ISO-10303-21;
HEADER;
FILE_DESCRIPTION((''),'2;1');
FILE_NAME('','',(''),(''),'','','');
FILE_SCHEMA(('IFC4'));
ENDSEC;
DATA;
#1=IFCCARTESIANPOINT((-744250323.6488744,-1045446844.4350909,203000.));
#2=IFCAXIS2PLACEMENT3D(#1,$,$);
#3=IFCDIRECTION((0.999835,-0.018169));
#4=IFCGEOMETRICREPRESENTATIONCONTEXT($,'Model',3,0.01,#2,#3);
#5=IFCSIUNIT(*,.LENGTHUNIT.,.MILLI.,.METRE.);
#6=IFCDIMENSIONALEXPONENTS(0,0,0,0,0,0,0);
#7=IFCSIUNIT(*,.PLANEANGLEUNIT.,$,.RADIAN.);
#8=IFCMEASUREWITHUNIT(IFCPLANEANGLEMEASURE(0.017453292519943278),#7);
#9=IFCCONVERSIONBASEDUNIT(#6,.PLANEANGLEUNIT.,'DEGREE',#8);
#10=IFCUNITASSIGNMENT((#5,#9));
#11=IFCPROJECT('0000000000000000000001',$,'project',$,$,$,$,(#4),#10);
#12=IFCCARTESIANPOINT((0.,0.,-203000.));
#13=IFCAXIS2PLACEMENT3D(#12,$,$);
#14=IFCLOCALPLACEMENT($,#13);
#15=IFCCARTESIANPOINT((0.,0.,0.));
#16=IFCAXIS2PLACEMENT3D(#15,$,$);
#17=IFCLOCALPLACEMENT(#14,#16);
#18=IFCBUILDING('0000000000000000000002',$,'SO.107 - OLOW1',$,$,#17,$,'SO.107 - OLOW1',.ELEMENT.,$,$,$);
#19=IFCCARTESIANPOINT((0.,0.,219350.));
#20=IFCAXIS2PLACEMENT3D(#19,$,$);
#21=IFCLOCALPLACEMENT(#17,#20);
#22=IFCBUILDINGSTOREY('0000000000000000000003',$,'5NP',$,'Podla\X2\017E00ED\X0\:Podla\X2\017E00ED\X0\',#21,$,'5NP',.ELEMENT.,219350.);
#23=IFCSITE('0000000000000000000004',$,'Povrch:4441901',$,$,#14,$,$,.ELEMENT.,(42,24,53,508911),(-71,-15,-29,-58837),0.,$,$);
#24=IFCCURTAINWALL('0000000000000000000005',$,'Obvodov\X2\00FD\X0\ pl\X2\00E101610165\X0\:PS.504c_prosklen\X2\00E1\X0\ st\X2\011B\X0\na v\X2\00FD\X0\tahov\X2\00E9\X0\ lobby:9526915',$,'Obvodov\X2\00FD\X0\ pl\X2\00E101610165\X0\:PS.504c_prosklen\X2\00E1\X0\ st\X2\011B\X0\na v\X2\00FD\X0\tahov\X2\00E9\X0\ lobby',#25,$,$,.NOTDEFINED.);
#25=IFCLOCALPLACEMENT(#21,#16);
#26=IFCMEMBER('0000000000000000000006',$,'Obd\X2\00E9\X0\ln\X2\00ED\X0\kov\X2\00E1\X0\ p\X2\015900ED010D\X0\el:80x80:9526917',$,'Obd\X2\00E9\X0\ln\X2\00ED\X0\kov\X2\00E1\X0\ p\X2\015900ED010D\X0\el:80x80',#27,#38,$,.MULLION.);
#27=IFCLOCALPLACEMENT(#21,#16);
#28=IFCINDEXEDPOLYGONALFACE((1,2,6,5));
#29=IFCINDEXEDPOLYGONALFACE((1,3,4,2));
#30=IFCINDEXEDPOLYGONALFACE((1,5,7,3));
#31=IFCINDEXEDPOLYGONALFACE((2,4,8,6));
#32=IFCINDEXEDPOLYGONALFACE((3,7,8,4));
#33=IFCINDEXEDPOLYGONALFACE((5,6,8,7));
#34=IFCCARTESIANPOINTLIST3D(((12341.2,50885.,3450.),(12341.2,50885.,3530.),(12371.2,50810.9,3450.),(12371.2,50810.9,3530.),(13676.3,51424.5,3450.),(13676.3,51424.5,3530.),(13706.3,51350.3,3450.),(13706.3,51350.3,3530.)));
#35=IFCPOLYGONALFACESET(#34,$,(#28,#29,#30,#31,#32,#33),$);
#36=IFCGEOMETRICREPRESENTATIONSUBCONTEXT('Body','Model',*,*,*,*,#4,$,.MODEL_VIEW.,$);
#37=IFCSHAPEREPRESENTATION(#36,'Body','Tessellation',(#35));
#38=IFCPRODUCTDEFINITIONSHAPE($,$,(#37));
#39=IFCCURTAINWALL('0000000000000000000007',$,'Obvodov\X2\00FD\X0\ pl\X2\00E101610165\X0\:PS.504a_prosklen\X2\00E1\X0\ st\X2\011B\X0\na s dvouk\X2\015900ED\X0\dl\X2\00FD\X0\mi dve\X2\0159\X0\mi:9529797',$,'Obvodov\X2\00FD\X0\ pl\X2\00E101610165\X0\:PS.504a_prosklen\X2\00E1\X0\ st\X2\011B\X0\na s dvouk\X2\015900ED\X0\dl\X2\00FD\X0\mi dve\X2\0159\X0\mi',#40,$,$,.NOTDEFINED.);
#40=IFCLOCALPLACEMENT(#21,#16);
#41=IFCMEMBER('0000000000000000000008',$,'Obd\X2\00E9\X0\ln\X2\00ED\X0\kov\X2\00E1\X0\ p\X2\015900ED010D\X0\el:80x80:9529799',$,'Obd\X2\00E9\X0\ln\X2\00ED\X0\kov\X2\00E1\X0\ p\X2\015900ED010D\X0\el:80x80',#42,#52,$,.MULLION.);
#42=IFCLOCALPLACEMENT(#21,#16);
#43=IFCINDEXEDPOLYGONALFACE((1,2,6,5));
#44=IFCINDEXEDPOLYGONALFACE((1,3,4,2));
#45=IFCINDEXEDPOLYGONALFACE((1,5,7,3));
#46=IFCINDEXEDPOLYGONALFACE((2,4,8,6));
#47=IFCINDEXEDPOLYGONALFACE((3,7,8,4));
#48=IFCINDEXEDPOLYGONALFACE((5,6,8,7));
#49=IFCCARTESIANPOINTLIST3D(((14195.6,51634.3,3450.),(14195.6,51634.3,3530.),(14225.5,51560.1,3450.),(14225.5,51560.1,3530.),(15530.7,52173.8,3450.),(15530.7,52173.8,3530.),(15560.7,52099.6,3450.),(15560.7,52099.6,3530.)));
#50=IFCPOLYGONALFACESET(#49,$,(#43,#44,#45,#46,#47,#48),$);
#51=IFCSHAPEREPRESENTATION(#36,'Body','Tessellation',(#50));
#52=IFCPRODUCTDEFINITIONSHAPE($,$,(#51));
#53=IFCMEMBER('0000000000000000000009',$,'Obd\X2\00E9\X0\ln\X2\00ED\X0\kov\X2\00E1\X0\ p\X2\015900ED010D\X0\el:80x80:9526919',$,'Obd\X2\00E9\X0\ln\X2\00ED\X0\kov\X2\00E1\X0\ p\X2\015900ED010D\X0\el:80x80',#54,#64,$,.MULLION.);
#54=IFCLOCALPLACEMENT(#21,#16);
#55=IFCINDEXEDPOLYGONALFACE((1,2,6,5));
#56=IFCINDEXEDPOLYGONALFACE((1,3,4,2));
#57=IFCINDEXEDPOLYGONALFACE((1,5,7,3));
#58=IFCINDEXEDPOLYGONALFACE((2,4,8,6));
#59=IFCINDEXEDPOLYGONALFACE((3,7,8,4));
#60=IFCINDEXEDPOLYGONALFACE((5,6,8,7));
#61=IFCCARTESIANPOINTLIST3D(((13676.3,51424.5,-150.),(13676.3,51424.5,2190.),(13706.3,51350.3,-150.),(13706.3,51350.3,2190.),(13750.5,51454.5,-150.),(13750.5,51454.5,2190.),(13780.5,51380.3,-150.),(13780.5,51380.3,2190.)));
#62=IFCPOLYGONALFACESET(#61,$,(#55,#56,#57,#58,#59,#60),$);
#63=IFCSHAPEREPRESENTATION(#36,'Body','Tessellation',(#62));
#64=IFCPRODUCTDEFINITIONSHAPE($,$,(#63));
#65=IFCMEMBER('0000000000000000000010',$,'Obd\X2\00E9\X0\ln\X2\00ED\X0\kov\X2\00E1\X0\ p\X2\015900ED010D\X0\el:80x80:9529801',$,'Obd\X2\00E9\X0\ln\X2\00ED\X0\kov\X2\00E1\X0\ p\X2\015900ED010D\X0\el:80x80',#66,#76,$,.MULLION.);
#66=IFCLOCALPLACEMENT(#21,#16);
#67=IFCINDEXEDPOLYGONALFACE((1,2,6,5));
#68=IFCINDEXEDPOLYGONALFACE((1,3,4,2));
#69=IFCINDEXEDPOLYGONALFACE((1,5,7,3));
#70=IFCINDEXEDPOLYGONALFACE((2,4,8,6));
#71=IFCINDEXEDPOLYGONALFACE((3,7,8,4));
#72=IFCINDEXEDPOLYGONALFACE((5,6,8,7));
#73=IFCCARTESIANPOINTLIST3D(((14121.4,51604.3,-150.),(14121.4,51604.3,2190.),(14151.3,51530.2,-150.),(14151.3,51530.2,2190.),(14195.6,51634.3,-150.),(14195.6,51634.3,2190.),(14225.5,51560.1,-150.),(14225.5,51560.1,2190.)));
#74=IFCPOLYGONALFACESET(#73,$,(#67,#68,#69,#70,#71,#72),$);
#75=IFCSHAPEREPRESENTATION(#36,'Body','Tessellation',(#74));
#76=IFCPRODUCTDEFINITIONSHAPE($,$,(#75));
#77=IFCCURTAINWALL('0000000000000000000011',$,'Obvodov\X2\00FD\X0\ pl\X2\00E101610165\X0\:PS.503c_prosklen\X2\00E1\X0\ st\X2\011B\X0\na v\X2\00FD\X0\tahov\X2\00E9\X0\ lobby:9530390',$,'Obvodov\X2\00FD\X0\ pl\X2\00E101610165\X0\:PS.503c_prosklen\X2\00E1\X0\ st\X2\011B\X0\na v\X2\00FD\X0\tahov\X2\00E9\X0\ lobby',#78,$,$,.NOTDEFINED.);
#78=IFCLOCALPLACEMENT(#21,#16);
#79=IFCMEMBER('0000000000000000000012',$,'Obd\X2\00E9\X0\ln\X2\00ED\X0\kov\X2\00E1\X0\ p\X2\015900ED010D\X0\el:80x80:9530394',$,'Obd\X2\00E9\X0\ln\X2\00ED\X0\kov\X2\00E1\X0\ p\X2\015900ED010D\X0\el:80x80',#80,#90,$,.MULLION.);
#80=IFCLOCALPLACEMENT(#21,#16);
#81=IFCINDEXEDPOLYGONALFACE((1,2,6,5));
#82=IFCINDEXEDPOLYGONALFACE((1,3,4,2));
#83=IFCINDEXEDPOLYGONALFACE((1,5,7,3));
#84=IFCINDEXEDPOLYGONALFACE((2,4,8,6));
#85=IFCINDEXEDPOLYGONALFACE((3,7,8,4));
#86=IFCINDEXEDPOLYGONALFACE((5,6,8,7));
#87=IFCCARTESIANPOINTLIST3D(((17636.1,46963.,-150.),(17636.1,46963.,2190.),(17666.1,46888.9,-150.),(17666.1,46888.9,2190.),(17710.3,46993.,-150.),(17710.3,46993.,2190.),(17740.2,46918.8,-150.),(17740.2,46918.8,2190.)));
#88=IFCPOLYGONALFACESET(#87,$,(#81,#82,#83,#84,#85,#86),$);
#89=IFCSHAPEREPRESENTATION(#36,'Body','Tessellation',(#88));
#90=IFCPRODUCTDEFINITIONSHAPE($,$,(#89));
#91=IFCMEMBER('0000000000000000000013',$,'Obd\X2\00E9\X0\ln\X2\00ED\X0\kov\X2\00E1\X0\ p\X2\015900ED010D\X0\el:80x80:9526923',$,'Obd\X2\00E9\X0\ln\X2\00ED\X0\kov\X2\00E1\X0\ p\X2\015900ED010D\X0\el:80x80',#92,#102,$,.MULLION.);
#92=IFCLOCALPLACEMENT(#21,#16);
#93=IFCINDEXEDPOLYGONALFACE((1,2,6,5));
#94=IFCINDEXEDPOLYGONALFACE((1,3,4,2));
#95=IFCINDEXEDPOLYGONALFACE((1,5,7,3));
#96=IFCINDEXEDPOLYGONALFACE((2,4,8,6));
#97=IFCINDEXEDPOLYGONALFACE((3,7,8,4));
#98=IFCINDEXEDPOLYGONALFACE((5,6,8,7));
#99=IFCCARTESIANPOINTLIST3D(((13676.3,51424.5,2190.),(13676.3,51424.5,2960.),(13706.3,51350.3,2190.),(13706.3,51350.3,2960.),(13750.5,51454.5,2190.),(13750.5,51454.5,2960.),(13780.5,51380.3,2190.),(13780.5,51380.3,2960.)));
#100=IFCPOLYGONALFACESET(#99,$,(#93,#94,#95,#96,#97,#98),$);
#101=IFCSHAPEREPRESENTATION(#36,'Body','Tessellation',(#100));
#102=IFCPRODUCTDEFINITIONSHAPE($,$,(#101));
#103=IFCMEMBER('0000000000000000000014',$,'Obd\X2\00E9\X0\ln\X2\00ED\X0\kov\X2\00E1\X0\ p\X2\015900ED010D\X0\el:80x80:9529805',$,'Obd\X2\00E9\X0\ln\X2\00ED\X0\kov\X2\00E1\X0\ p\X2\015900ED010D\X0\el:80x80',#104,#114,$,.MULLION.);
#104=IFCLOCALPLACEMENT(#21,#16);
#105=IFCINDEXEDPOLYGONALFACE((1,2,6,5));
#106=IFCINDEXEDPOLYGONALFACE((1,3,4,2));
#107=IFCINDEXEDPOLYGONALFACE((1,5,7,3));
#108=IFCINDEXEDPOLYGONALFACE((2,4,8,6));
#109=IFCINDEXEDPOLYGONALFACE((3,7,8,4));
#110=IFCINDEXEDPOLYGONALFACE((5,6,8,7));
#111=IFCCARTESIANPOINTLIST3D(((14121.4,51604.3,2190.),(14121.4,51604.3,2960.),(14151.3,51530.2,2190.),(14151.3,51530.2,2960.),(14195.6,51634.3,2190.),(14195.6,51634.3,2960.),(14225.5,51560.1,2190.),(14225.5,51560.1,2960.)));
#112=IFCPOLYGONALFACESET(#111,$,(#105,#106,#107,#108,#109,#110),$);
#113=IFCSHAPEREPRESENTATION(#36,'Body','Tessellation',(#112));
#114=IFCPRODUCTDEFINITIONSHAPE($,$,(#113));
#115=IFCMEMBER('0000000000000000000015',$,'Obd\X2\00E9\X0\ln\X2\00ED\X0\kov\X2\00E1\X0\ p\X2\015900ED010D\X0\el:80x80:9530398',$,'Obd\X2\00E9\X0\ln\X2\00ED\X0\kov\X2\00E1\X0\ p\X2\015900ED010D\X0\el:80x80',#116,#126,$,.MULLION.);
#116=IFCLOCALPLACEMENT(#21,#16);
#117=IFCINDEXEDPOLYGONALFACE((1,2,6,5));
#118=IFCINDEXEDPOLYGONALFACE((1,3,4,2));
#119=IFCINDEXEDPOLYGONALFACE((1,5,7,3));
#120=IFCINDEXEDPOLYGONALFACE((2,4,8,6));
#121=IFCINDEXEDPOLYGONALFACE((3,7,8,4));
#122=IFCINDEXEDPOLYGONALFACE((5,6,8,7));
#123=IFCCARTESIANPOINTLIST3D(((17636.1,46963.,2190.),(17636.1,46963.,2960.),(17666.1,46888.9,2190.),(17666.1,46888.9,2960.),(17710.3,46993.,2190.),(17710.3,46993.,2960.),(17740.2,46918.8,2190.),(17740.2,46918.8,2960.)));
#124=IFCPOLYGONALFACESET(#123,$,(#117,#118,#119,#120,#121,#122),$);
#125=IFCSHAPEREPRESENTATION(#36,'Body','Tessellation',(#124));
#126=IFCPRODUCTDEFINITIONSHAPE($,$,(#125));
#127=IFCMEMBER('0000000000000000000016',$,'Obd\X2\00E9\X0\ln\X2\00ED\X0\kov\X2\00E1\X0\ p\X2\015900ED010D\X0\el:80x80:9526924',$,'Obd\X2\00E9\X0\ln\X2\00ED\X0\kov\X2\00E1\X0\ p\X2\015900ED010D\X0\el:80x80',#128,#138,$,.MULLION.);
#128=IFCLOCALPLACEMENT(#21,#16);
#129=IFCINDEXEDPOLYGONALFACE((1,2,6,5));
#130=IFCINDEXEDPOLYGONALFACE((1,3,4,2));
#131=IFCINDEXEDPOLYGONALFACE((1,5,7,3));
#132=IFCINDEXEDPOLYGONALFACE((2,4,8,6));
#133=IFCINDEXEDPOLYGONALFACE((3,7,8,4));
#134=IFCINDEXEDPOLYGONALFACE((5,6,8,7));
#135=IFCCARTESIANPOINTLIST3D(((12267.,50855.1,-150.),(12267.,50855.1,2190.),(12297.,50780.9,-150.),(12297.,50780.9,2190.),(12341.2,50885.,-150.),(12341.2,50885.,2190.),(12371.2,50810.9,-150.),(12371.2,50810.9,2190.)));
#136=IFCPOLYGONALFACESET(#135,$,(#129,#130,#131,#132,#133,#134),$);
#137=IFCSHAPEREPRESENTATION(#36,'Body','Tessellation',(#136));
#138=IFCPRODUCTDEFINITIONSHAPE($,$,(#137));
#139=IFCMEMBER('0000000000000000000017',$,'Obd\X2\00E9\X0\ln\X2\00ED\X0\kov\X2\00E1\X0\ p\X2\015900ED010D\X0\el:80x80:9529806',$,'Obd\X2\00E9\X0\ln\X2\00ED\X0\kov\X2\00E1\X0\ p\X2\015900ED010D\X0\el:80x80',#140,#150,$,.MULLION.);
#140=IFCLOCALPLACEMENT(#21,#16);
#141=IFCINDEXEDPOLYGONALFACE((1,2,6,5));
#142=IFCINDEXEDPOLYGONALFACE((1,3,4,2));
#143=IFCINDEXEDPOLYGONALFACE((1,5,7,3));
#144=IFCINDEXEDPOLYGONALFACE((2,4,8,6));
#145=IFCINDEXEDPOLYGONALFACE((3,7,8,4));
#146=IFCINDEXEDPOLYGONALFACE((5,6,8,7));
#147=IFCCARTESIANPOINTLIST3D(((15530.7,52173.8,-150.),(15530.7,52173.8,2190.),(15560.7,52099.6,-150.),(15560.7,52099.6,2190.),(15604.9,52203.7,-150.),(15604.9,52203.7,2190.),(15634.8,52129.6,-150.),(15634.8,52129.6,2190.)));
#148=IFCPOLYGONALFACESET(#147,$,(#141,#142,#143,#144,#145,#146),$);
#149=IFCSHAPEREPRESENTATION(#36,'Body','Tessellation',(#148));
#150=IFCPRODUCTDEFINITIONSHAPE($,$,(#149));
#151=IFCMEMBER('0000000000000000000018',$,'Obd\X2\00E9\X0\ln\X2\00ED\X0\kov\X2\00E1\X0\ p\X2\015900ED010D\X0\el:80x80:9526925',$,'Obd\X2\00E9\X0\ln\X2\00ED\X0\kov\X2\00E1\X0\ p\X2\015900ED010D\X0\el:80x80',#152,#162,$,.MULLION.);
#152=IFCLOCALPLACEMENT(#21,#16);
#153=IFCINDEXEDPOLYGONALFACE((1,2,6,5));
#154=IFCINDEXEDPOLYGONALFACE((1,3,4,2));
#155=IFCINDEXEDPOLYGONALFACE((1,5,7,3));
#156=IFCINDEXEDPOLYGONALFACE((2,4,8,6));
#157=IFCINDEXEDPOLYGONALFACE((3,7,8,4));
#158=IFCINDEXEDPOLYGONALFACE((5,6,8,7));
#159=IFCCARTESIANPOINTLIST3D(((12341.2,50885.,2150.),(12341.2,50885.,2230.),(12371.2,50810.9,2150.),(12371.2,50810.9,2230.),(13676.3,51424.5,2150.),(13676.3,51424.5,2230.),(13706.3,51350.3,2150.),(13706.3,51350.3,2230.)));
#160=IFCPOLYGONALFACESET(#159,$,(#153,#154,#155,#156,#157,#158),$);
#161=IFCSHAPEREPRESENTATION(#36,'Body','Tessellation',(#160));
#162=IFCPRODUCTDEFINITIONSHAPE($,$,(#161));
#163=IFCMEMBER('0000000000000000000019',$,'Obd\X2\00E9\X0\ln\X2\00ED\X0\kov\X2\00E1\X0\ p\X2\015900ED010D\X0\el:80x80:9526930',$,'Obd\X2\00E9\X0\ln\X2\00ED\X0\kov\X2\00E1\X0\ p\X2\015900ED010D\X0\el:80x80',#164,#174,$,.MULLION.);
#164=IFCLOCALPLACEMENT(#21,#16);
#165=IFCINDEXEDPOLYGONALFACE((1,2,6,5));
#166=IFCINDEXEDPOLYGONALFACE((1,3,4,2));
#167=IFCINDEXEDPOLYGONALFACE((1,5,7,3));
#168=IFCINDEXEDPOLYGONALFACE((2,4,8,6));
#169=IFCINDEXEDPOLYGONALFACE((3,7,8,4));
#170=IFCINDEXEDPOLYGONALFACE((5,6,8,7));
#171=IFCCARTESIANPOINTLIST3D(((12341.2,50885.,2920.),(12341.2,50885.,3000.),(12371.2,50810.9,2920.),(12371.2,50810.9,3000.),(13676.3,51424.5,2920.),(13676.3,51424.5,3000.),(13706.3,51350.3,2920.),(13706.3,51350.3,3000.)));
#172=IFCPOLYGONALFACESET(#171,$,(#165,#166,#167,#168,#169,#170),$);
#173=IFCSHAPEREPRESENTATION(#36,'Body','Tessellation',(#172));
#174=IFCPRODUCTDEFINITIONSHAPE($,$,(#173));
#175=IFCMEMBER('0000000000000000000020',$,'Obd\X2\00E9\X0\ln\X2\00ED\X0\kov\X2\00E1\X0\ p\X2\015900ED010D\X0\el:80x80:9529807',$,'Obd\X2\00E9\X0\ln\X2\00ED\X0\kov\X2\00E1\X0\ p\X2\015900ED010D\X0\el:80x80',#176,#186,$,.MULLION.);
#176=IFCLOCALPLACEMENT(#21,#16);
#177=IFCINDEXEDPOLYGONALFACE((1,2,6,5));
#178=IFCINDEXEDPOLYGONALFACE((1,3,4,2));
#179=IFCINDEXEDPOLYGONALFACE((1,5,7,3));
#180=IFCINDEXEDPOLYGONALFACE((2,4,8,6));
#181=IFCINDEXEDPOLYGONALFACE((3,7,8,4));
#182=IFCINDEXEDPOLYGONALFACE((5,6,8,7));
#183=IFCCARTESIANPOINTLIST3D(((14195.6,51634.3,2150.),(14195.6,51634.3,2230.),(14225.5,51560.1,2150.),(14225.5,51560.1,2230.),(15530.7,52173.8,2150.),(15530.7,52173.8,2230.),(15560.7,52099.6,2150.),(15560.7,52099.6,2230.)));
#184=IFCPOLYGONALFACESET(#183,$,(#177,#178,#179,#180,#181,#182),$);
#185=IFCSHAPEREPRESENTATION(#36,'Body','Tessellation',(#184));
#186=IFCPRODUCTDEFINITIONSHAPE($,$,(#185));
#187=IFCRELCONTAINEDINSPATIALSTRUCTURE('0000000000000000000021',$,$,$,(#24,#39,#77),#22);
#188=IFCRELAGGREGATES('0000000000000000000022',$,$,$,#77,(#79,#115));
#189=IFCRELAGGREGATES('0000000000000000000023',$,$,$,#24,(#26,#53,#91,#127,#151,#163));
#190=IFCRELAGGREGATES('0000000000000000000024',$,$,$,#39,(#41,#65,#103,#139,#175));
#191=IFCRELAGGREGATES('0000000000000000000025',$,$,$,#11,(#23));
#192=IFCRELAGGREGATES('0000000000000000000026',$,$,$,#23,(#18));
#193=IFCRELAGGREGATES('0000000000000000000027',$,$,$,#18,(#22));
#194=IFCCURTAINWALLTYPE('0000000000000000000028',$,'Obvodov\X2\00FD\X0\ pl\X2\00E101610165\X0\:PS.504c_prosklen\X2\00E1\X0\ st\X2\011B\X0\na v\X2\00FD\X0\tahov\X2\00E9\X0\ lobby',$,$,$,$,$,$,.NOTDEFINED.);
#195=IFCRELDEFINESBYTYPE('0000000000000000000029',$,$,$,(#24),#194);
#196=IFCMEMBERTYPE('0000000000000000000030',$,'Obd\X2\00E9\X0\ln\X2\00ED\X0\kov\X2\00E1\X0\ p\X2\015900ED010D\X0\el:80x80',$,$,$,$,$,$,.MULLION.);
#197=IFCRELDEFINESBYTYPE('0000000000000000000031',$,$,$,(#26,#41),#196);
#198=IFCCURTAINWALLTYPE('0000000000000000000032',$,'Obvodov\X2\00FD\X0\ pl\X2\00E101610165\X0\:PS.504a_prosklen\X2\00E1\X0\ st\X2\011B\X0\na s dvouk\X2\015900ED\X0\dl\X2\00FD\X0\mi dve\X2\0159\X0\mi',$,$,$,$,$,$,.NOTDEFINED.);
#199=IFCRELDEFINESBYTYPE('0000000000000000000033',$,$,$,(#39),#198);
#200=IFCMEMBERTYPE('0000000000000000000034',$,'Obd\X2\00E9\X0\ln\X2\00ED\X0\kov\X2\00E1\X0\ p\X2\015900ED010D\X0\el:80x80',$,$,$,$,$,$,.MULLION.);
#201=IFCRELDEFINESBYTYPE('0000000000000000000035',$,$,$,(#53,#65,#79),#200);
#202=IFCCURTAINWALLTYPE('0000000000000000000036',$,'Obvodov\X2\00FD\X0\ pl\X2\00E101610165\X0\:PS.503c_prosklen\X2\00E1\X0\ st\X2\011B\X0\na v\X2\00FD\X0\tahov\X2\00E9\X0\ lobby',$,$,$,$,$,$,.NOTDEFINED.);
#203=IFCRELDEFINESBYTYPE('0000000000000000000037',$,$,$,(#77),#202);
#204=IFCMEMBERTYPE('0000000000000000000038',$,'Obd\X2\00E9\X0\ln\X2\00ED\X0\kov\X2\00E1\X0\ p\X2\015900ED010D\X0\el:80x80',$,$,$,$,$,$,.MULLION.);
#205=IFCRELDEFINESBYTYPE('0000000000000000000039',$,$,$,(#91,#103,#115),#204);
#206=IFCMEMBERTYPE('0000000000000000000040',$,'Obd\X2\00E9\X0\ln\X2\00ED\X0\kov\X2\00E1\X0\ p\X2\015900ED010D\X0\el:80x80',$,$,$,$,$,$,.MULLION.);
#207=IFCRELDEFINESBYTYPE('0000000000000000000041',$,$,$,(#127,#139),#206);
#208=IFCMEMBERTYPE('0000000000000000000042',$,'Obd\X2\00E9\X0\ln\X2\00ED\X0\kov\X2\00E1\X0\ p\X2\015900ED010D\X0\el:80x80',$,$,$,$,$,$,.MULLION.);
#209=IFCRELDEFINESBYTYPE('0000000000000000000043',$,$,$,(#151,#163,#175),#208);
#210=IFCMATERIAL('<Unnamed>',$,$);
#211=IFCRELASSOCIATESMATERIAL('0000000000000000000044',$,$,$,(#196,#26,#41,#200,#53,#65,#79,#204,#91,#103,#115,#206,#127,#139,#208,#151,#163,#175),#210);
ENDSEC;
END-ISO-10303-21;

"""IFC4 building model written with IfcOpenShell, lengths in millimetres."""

from ifc_helpers import new_model, entity, si_unit, converted_unit, direction, frame, origin, place, context, subcontext, project, spatial, indexed_curve, outline, extrude, source, transform, mapped, material, type_object, type_shapes, element, aggregate, save


model = new_model("IFC4")

# Units and contexts
model_context = context("Model", 3, precision=0.01, world=frame((-744250323.6488744, -1045446844.4350909, 203000.0)), true_north=direction((0.999835, -0.018169)))
body_context = subcontext(model_context, "Body", "Model", "MODEL_VIEW")
ifc_project = project(units=[si_unit("LENGTHUNIT", "METRE", prefix="MILLI"), converted_unit("PLANEANGLEUNIT", "DEGREE", entity("IfcPlaneAngleMeasure", 0.017453292519943278), si_unit("PLANEANGLEUNIT", "RADIAN"), dimensions=[0, 0, 0, 0, 0, 0, 0])], contexts=[model_context])

# Site, building, storey
site_placement = place(None, frame((0.0, 0.0, -203000.0)))
site = spatial("IfcSite", under=ifc_project, at=site_placement, Name="Povrch:4441901", CompositionType="ELEMENT", RefLatitude=(42, 24, 53, 508911), RefLongitude=(-71, -15, -29, -58837), RefElevation=0.0)
building_placement = place(site_placement, origin())
building = spatial("IfcBuilding", under=site, at=building_placement, Name="SO.107 - OLOW1", LongName="SO.107 - OLOW1", CompositionType="ELEMENT")
storey_placement = place(building_placement, frame((0.0, 0.0, 219350.0)))
storey = spatial("IfcBuildingStorey", under=building, at=storey_placement, Name="5NP", ObjectType="Podlaží:Podlaží", LongName="5NP", CompositionType="ELEMENT", Elevation=219350.0)

# Curtain walls, members
curtain_wall_type_1 = type_object("IfcCurtainWallType", Name="Obvodový plášť:PS.504c_prosklená stěna výtahové lobby", PredefinedType="NOTDEFINED")
curtain_wall_1_placement = place(storey_placement, frame((0.0, 0.0, -219350.0)))
curtain_wall_1 = element("IfcCurtainWall", 1, at=curtain_wall_1_placement, inside=storey, type_object=curtain_wall_type_1, Name="Obvodový plášť:PS.504c_prosklená stěna výtahové lobby:9526915", ObjectType="Obvodový plášť:PS.504c_prosklená stěna výtahové lobby", PredefinedType="NOTDEFINED")
ifc_material_1 = material(Name="<Unnamed>")
member_type_1 = type_object("IfcMemberType", Name="Obdélníková příčel:80x80", PredefinedType="MULLION", material=ifc_material_1)
shared_shape_1 = source(origin(), body_context, "Body", "SweptSolid", [
    extrude(outline(indexed_curve([(-40.0, -40.0), (40.0, -40.0), (40.0, 40.0), (-40.0, 40.0), (-40.0, -40.0)], self_intersect=False)), frame((-40.0, 0.0, -1440.0), z_axis=(0.0, 0.0, 1.0), x_axis=(-1.0, 0.0, 0.0)), (0.0, 0.0, 1.0), 1440.0),
])
type_shapes(member_type_1, [shared_shape_1])
member_1_placement = place(curtain_wall_1_placement, frame((13691.3, 51387.4, 222880.0), z_axis=(0.927176, 0.374626, 0.0), x_axis=(0.0, 0.0, 1.0)))
member_1 = element("IfcMember", 2, at=member_1_placement, type_object=member_type_1, material=ifc_material_1, Name="Obdélníková příčel:80x80:9526917", ObjectType="Obdélníková příčel:80x80", PredefinedType="MULLION", context=body_context, shape_type="MappedRepresentation", body=[
    mapped(shared_shape_1, transform((0.0, 0.0, 0.0), scale=1.0)),
])
curtain_wall_type_2 = type_object("IfcCurtainWallType", Name="Obvodový plášť:PS.504a_prosklená stěna s dvoukřídlými dveřmi", PredefinedType="NOTDEFINED")
curtain_wall_2_placement = place(storey_placement, frame((0.0, 0.0, -219350.0)))
curtain_wall_2 = element("IfcCurtainWall", 3, at=curtain_wall_2_placement, inside=storey, type_object=curtain_wall_type_2, Name="Obvodový plášť:PS.504a_prosklená stěna s dvoukřídlými dveřmi:9529797", ObjectType="Obvodový plášť:PS.504a_prosklená stěna s dvoukřídlými dveřmi", PredefinedType="NOTDEFINED")
member_2_placement = place(curtain_wall_2_placement, frame((14210.5, 51597.2, 222880.0), z_axis=(-0.927176, -0.374626, 0.0), x_axis=(0.0, 0.0, 1.0)))
member_2 = element("IfcMember", 4, at=member_2_placement, type_object=member_type_1, material=ifc_material_1, Name="Obdélníková příčel:80x80:9529799", ObjectType="Obdélníková příčel:80x80", PredefinedType="MULLION", context=body_context, shape_type="MappedRepresentation", body=[
    mapped(shared_shape_1, transform((0.0, 0.0, 0.0), scale=1.0)),
])

# Members
member_type_2 = type_object("IfcMemberType", Name="Obdélníková příčel:80x80", PredefinedType="MULLION", material=ifc_material_1)
shared_shape_2 = source(origin(), body_context, "Body", "SweptSolid", [
    extrude(outline(indexed_curve([(-40.0, -40.0), (40.0, -40.0), (40.0, 40.0), (-40.0, 40.0), (-40.0, -40.0)], self_intersect=False)), frame((-40.0, 0.0, -2340.0), z_axis=(0.0, 0.0, 1.0), x_axis=(-1.0, 0.0, 0.0)), (0.0, 0.0, 1.0), 2340.0),
])
type_shapes(member_type_2, [shared_shape_2])
member_3_placement = place(curtain_wall_1_placement, frame((13765.5, 51417.4, 219200.0), z_axis=(0.0, 0.0, -1.0), x_axis=(0.927176, 0.374626, 0.0)))
member_3 = element("IfcMember", 5, at=member_3_placement, type_object=member_type_2, material=ifc_material_1, Name="Obdélníková příčel:80x80:9526919", ObjectType="Obdélníková příčel:80x80", PredefinedType="MULLION", context=body_context, shape_type="MappedRepresentation", body=[
    mapped(shared_shape_2, transform((0.0, 0.0, 0.0), scale=1.0)),
])
member_4_placement = place(curtain_wall_2_placement, frame((14136.4, 51567.2, 219200.0), z_axis=(0.0, 0.0, -1.0), x_axis=(-0.927176, -0.374626, 0.0)))
member_4 = element("IfcMember", 6, at=member_4_placement, type_object=member_type_2, material=ifc_material_1, Name="Obdélníková příčel:80x80:9529801", ObjectType="Obdélníková příčel:80x80", PredefinedType="MULLION", context=body_context, shape_type="MappedRepresentation", body=[
    mapped(shared_shape_2, transform((0.0, 0.0, 0.0), scale=1.0)),
])

# Curtain wall, member
curtain_wall_type_3 = type_object("IfcCurtainWallType", Name="Obvodový plášť:PS.503c_prosklená stěna výtahové lobby", PredefinedType="NOTDEFINED")
curtain_wall_3_placement = place(storey_placement, frame((0.0, 0.0, -219350.0)))
curtain_wall_3 = element("IfcCurtainWall", 7, at=curtain_wall_3_placement, inside=storey, type_object=curtain_wall_type_3, Name="Obvodový plášť:PS.503c_prosklená stěna výtahové lobby:9530390", ObjectType="Obvodový plášť:PS.503c_prosklená stěna výtahové lobby", PredefinedType="NOTDEFINED")
member_5_placement = place(curtain_wall_3_placement, frame((17725.2, 46955.9, 219200.0), z_axis=(0.0, 0.0, -1.0), x_axis=(0.927176, 0.374626, 0.0)))
member_5 = element("IfcMember", 8, at=member_5_placement, type_object=member_type_2, material=ifc_material_1, Name="Obdélníková příčel:80x80:9530394", ObjectType="Obdélníková příčel:80x80", PredefinedType="MULLION", context=body_context, shape_type="MappedRepresentation", body=[
    mapped(shared_shape_2, transform((0.0, 0.0, 0.0), scale=1.0)),
])

# Members
member_type_3 = type_object("IfcMemberType", Name="Obdélníková příčel:80x80", PredefinedType="MULLION", material=ifc_material_1)
shared_shape_3 = source(origin(), body_context, "Body", "SweptSolid", [
    extrude(outline(indexed_curve([(-40.0, -40.0), (40.0, -40.0), (40.0, 40.0), (-40.0, 40.0), (-40.0, -40.0)], self_intersect=False)), frame((-40.0, 0.0, -770.0), z_axis=(0.0, 0.0, 1.0), x_axis=(-1.0, 0.0, 0.0)), (0.0, 0.0, 1.0), 770.0),
])
type_shapes(member_type_3, [shared_shape_3])
member_6_placement = place(curtain_wall_1_placement, frame((13765.5, 51417.4, 221540.0), z_axis=(0.0, 0.0, -1.0), x_axis=(0.927176, 0.374626, 0.0)))
member_6 = element("IfcMember", 9, at=member_6_placement, type_object=member_type_3, material=ifc_material_1, Name="Obdélníková příčel:80x80:9526923", ObjectType="Obdélníková příčel:80x80", PredefinedType="MULLION", context=body_context, shape_type="MappedRepresentation", body=[
    mapped(shared_shape_3, transform((0.0, 0.0, 0.0), scale=1.0)),
])
member_7_placement = place(curtain_wall_2_placement, frame((14136.4, 51567.2, 221540.0), z_axis=(0.0, 0.0, -1.0), x_axis=(-0.927176, -0.374626, 0.0)))
member_7 = element("IfcMember", 10, at=member_7_placement, type_object=member_type_3, material=ifc_material_1, Name="Obdélníková příčel:80x80:9529805", ObjectType="Obdélníková příčel:80x80", PredefinedType="MULLION", context=body_context, shape_type="MappedRepresentation", body=[
    mapped(shared_shape_3, transform((0.0, 0.0, 0.0), scale=1.0)),
])
member_8_placement = place(curtain_wall_3_placement, frame((17725.2, 46955.9, 221540.0), z_axis=(0.0, 0.0, -1.0), x_axis=(0.927176, 0.374626, 0.0)))
member_8 = element("IfcMember", 11, at=member_8_placement, type_object=member_type_3, material=ifc_material_1, Name="Obdélníková příčel:80x80:9530398", ObjectType="Obdélníková příčel:80x80", PredefinedType="MULLION", context=body_context, shape_type="MappedRepresentation", body=[
    mapped(shared_shape_3, transform((0.0, 0.0, 0.0), scale=1.0)),
])
member_type_4 = type_object("IfcMemberType", Name="Obdélníková příčel:80x80", PredefinedType="MULLION", material=ifc_material_1)
shared_shape_4 = source(origin(), body_context, "Body", "SweptSolid", [
    extrude(outline(indexed_curve([(-40.0, -40.0), (40.0, -40.0), (40.0, 40.0), (-40.0, 40.0), (-40.0, -40.0)], self_intersect=False)), frame((-40.0, 0.0, -2340.0), z_axis=(0.0, 0.0, 1.0), x_axis=(-1.0, 0.0, 0.0)), (0.0, 0.0, 1.0), 2340.0),
])
type_shapes(member_type_4, [shared_shape_4])
member_9_placement = place(curtain_wall_1_placement, frame((12282.0, 50818.0, 221540.0), z_axis=(0.0, 0.0, 1.0), x_axis=(-0.927176, -0.374626, 0.0)))
member_9 = element("IfcMember", 12, at=member_9_placement, type_object=member_type_4, material=ifc_material_1, Name="Obdélníková příčel:80x80:9526924", ObjectType="Obdélníková příčel:80x80", PredefinedType="MULLION", context=body_context, shape_type="MappedRepresentation", body=[
    mapped(shared_shape_4, transform((0.0, 0.0, 0.0), scale=1.0)),
])
member_10_placement = place(curtain_wall_2_placement, frame((15619.8, 52166.6, 221540.0), z_axis=(0.0, 0.0, 1.0), x_axis=(0.927176, 0.374626, 0.0)))
member_10 = element("IfcMember", 13, at=member_10_placement, type_object=member_type_4, material=ifc_material_1, Name="Obdélníková příčel:80x80:9529806", ObjectType="Obdélníková příčel:80x80", PredefinedType="MULLION", context=body_context, shape_type="MappedRepresentation", body=[
    mapped(shared_shape_4, transform((0.0, 0.0, 0.0), scale=1.0)),
])
member_type_5 = type_object("IfcMemberType", Name="Obdélníková příčel:80x80", PredefinedType="MULLION", material=ifc_material_1)
shared_shape_5 = source(origin(), body_context, "Body", "SweptSolid", [
    extrude(outline(indexed_curve([(-40.0, -40.0), (40.0, -40.0), (40.0, 40.0), (-40.0, 40.0), (-40.0, -40.0)], self_intersect=False)), frame((0.0, 0.0, -1440.0), z_axis=(0.0, 0.0, 1.0), x_axis=(-1.0, 0.0, 0.0)), (0.0, 0.0, 1.0), 1440.0),
])
type_shapes(member_type_5, [shared_shape_5])
member_11_placement = place(curtain_wall_1_placement, frame((13691.3, 51387.4, 221540.0), z_axis=(0.927176, 0.374626, 0.0), x_axis=(0.0, 0.0, 1.0)))
member_11 = element("IfcMember", 14, at=member_11_placement, type_object=member_type_5, material=ifc_material_1, Name="Obdélníková příčel:80x80:9526925", ObjectType="Obdélníková příčel:80x80", PredefinedType="MULLION", context=body_context, shape_type="MappedRepresentation", body=[
    mapped(shared_shape_5, transform((0.0, 0.0, 0.0), scale=1.0)),
])
member_12_placement = place(curtain_wall_1_placement, frame((13691.3, 51387.4, 222310.0), z_axis=(0.927176, 0.374626, 0.0), x_axis=(0.0, 0.0, 1.0)))
member_12 = element("IfcMember", 15, at=member_12_placement, type_object=member_type_5, material=ifc_material_1, Name="Obdélníková příčel:80x80:9526930", ObjectType="Obdélníková příčel:80x80", PredefinedType="MULLION", context=body_context, shape_type="MappedRepresentation", body=[
    mapped(shared_shape_5, transform((0.0, 0.0, 0.0), scale=1.0)),
])
member_13_placement = place(curtain_wall_2_placement, frame((14210.5, 51597.2, 221540.0), z_axis=(-0.927176, -0.374626, 0.0), x_axis=(0.0, 0.0, 1.0)))
member_13 = element("IfcMember", 16, at=member_13_placement, type_object=member_type_5, material=ifc_material_1, Name="Obdélníková příčel:80x80:9529807", ObjectType="Obdélníková příčel:80x80", PredefinedType="MULLION", context=body_context, shape_type="MappedRepresentation", body=[
    mapped(shared_shape_5, transform((0.0, 0.0, 0.0), scale=1.0)),
])
aggregate(curtain_wall_3, [member_5, member_8])

aggregate(curtain_wall_1, [member_1, member_3, member_6, member_9, member_11, member_12])

aggregate(curtain_wall_2, [member_2, member_4, member_7, member_10, member_13])

save(model, "model.ifc")
